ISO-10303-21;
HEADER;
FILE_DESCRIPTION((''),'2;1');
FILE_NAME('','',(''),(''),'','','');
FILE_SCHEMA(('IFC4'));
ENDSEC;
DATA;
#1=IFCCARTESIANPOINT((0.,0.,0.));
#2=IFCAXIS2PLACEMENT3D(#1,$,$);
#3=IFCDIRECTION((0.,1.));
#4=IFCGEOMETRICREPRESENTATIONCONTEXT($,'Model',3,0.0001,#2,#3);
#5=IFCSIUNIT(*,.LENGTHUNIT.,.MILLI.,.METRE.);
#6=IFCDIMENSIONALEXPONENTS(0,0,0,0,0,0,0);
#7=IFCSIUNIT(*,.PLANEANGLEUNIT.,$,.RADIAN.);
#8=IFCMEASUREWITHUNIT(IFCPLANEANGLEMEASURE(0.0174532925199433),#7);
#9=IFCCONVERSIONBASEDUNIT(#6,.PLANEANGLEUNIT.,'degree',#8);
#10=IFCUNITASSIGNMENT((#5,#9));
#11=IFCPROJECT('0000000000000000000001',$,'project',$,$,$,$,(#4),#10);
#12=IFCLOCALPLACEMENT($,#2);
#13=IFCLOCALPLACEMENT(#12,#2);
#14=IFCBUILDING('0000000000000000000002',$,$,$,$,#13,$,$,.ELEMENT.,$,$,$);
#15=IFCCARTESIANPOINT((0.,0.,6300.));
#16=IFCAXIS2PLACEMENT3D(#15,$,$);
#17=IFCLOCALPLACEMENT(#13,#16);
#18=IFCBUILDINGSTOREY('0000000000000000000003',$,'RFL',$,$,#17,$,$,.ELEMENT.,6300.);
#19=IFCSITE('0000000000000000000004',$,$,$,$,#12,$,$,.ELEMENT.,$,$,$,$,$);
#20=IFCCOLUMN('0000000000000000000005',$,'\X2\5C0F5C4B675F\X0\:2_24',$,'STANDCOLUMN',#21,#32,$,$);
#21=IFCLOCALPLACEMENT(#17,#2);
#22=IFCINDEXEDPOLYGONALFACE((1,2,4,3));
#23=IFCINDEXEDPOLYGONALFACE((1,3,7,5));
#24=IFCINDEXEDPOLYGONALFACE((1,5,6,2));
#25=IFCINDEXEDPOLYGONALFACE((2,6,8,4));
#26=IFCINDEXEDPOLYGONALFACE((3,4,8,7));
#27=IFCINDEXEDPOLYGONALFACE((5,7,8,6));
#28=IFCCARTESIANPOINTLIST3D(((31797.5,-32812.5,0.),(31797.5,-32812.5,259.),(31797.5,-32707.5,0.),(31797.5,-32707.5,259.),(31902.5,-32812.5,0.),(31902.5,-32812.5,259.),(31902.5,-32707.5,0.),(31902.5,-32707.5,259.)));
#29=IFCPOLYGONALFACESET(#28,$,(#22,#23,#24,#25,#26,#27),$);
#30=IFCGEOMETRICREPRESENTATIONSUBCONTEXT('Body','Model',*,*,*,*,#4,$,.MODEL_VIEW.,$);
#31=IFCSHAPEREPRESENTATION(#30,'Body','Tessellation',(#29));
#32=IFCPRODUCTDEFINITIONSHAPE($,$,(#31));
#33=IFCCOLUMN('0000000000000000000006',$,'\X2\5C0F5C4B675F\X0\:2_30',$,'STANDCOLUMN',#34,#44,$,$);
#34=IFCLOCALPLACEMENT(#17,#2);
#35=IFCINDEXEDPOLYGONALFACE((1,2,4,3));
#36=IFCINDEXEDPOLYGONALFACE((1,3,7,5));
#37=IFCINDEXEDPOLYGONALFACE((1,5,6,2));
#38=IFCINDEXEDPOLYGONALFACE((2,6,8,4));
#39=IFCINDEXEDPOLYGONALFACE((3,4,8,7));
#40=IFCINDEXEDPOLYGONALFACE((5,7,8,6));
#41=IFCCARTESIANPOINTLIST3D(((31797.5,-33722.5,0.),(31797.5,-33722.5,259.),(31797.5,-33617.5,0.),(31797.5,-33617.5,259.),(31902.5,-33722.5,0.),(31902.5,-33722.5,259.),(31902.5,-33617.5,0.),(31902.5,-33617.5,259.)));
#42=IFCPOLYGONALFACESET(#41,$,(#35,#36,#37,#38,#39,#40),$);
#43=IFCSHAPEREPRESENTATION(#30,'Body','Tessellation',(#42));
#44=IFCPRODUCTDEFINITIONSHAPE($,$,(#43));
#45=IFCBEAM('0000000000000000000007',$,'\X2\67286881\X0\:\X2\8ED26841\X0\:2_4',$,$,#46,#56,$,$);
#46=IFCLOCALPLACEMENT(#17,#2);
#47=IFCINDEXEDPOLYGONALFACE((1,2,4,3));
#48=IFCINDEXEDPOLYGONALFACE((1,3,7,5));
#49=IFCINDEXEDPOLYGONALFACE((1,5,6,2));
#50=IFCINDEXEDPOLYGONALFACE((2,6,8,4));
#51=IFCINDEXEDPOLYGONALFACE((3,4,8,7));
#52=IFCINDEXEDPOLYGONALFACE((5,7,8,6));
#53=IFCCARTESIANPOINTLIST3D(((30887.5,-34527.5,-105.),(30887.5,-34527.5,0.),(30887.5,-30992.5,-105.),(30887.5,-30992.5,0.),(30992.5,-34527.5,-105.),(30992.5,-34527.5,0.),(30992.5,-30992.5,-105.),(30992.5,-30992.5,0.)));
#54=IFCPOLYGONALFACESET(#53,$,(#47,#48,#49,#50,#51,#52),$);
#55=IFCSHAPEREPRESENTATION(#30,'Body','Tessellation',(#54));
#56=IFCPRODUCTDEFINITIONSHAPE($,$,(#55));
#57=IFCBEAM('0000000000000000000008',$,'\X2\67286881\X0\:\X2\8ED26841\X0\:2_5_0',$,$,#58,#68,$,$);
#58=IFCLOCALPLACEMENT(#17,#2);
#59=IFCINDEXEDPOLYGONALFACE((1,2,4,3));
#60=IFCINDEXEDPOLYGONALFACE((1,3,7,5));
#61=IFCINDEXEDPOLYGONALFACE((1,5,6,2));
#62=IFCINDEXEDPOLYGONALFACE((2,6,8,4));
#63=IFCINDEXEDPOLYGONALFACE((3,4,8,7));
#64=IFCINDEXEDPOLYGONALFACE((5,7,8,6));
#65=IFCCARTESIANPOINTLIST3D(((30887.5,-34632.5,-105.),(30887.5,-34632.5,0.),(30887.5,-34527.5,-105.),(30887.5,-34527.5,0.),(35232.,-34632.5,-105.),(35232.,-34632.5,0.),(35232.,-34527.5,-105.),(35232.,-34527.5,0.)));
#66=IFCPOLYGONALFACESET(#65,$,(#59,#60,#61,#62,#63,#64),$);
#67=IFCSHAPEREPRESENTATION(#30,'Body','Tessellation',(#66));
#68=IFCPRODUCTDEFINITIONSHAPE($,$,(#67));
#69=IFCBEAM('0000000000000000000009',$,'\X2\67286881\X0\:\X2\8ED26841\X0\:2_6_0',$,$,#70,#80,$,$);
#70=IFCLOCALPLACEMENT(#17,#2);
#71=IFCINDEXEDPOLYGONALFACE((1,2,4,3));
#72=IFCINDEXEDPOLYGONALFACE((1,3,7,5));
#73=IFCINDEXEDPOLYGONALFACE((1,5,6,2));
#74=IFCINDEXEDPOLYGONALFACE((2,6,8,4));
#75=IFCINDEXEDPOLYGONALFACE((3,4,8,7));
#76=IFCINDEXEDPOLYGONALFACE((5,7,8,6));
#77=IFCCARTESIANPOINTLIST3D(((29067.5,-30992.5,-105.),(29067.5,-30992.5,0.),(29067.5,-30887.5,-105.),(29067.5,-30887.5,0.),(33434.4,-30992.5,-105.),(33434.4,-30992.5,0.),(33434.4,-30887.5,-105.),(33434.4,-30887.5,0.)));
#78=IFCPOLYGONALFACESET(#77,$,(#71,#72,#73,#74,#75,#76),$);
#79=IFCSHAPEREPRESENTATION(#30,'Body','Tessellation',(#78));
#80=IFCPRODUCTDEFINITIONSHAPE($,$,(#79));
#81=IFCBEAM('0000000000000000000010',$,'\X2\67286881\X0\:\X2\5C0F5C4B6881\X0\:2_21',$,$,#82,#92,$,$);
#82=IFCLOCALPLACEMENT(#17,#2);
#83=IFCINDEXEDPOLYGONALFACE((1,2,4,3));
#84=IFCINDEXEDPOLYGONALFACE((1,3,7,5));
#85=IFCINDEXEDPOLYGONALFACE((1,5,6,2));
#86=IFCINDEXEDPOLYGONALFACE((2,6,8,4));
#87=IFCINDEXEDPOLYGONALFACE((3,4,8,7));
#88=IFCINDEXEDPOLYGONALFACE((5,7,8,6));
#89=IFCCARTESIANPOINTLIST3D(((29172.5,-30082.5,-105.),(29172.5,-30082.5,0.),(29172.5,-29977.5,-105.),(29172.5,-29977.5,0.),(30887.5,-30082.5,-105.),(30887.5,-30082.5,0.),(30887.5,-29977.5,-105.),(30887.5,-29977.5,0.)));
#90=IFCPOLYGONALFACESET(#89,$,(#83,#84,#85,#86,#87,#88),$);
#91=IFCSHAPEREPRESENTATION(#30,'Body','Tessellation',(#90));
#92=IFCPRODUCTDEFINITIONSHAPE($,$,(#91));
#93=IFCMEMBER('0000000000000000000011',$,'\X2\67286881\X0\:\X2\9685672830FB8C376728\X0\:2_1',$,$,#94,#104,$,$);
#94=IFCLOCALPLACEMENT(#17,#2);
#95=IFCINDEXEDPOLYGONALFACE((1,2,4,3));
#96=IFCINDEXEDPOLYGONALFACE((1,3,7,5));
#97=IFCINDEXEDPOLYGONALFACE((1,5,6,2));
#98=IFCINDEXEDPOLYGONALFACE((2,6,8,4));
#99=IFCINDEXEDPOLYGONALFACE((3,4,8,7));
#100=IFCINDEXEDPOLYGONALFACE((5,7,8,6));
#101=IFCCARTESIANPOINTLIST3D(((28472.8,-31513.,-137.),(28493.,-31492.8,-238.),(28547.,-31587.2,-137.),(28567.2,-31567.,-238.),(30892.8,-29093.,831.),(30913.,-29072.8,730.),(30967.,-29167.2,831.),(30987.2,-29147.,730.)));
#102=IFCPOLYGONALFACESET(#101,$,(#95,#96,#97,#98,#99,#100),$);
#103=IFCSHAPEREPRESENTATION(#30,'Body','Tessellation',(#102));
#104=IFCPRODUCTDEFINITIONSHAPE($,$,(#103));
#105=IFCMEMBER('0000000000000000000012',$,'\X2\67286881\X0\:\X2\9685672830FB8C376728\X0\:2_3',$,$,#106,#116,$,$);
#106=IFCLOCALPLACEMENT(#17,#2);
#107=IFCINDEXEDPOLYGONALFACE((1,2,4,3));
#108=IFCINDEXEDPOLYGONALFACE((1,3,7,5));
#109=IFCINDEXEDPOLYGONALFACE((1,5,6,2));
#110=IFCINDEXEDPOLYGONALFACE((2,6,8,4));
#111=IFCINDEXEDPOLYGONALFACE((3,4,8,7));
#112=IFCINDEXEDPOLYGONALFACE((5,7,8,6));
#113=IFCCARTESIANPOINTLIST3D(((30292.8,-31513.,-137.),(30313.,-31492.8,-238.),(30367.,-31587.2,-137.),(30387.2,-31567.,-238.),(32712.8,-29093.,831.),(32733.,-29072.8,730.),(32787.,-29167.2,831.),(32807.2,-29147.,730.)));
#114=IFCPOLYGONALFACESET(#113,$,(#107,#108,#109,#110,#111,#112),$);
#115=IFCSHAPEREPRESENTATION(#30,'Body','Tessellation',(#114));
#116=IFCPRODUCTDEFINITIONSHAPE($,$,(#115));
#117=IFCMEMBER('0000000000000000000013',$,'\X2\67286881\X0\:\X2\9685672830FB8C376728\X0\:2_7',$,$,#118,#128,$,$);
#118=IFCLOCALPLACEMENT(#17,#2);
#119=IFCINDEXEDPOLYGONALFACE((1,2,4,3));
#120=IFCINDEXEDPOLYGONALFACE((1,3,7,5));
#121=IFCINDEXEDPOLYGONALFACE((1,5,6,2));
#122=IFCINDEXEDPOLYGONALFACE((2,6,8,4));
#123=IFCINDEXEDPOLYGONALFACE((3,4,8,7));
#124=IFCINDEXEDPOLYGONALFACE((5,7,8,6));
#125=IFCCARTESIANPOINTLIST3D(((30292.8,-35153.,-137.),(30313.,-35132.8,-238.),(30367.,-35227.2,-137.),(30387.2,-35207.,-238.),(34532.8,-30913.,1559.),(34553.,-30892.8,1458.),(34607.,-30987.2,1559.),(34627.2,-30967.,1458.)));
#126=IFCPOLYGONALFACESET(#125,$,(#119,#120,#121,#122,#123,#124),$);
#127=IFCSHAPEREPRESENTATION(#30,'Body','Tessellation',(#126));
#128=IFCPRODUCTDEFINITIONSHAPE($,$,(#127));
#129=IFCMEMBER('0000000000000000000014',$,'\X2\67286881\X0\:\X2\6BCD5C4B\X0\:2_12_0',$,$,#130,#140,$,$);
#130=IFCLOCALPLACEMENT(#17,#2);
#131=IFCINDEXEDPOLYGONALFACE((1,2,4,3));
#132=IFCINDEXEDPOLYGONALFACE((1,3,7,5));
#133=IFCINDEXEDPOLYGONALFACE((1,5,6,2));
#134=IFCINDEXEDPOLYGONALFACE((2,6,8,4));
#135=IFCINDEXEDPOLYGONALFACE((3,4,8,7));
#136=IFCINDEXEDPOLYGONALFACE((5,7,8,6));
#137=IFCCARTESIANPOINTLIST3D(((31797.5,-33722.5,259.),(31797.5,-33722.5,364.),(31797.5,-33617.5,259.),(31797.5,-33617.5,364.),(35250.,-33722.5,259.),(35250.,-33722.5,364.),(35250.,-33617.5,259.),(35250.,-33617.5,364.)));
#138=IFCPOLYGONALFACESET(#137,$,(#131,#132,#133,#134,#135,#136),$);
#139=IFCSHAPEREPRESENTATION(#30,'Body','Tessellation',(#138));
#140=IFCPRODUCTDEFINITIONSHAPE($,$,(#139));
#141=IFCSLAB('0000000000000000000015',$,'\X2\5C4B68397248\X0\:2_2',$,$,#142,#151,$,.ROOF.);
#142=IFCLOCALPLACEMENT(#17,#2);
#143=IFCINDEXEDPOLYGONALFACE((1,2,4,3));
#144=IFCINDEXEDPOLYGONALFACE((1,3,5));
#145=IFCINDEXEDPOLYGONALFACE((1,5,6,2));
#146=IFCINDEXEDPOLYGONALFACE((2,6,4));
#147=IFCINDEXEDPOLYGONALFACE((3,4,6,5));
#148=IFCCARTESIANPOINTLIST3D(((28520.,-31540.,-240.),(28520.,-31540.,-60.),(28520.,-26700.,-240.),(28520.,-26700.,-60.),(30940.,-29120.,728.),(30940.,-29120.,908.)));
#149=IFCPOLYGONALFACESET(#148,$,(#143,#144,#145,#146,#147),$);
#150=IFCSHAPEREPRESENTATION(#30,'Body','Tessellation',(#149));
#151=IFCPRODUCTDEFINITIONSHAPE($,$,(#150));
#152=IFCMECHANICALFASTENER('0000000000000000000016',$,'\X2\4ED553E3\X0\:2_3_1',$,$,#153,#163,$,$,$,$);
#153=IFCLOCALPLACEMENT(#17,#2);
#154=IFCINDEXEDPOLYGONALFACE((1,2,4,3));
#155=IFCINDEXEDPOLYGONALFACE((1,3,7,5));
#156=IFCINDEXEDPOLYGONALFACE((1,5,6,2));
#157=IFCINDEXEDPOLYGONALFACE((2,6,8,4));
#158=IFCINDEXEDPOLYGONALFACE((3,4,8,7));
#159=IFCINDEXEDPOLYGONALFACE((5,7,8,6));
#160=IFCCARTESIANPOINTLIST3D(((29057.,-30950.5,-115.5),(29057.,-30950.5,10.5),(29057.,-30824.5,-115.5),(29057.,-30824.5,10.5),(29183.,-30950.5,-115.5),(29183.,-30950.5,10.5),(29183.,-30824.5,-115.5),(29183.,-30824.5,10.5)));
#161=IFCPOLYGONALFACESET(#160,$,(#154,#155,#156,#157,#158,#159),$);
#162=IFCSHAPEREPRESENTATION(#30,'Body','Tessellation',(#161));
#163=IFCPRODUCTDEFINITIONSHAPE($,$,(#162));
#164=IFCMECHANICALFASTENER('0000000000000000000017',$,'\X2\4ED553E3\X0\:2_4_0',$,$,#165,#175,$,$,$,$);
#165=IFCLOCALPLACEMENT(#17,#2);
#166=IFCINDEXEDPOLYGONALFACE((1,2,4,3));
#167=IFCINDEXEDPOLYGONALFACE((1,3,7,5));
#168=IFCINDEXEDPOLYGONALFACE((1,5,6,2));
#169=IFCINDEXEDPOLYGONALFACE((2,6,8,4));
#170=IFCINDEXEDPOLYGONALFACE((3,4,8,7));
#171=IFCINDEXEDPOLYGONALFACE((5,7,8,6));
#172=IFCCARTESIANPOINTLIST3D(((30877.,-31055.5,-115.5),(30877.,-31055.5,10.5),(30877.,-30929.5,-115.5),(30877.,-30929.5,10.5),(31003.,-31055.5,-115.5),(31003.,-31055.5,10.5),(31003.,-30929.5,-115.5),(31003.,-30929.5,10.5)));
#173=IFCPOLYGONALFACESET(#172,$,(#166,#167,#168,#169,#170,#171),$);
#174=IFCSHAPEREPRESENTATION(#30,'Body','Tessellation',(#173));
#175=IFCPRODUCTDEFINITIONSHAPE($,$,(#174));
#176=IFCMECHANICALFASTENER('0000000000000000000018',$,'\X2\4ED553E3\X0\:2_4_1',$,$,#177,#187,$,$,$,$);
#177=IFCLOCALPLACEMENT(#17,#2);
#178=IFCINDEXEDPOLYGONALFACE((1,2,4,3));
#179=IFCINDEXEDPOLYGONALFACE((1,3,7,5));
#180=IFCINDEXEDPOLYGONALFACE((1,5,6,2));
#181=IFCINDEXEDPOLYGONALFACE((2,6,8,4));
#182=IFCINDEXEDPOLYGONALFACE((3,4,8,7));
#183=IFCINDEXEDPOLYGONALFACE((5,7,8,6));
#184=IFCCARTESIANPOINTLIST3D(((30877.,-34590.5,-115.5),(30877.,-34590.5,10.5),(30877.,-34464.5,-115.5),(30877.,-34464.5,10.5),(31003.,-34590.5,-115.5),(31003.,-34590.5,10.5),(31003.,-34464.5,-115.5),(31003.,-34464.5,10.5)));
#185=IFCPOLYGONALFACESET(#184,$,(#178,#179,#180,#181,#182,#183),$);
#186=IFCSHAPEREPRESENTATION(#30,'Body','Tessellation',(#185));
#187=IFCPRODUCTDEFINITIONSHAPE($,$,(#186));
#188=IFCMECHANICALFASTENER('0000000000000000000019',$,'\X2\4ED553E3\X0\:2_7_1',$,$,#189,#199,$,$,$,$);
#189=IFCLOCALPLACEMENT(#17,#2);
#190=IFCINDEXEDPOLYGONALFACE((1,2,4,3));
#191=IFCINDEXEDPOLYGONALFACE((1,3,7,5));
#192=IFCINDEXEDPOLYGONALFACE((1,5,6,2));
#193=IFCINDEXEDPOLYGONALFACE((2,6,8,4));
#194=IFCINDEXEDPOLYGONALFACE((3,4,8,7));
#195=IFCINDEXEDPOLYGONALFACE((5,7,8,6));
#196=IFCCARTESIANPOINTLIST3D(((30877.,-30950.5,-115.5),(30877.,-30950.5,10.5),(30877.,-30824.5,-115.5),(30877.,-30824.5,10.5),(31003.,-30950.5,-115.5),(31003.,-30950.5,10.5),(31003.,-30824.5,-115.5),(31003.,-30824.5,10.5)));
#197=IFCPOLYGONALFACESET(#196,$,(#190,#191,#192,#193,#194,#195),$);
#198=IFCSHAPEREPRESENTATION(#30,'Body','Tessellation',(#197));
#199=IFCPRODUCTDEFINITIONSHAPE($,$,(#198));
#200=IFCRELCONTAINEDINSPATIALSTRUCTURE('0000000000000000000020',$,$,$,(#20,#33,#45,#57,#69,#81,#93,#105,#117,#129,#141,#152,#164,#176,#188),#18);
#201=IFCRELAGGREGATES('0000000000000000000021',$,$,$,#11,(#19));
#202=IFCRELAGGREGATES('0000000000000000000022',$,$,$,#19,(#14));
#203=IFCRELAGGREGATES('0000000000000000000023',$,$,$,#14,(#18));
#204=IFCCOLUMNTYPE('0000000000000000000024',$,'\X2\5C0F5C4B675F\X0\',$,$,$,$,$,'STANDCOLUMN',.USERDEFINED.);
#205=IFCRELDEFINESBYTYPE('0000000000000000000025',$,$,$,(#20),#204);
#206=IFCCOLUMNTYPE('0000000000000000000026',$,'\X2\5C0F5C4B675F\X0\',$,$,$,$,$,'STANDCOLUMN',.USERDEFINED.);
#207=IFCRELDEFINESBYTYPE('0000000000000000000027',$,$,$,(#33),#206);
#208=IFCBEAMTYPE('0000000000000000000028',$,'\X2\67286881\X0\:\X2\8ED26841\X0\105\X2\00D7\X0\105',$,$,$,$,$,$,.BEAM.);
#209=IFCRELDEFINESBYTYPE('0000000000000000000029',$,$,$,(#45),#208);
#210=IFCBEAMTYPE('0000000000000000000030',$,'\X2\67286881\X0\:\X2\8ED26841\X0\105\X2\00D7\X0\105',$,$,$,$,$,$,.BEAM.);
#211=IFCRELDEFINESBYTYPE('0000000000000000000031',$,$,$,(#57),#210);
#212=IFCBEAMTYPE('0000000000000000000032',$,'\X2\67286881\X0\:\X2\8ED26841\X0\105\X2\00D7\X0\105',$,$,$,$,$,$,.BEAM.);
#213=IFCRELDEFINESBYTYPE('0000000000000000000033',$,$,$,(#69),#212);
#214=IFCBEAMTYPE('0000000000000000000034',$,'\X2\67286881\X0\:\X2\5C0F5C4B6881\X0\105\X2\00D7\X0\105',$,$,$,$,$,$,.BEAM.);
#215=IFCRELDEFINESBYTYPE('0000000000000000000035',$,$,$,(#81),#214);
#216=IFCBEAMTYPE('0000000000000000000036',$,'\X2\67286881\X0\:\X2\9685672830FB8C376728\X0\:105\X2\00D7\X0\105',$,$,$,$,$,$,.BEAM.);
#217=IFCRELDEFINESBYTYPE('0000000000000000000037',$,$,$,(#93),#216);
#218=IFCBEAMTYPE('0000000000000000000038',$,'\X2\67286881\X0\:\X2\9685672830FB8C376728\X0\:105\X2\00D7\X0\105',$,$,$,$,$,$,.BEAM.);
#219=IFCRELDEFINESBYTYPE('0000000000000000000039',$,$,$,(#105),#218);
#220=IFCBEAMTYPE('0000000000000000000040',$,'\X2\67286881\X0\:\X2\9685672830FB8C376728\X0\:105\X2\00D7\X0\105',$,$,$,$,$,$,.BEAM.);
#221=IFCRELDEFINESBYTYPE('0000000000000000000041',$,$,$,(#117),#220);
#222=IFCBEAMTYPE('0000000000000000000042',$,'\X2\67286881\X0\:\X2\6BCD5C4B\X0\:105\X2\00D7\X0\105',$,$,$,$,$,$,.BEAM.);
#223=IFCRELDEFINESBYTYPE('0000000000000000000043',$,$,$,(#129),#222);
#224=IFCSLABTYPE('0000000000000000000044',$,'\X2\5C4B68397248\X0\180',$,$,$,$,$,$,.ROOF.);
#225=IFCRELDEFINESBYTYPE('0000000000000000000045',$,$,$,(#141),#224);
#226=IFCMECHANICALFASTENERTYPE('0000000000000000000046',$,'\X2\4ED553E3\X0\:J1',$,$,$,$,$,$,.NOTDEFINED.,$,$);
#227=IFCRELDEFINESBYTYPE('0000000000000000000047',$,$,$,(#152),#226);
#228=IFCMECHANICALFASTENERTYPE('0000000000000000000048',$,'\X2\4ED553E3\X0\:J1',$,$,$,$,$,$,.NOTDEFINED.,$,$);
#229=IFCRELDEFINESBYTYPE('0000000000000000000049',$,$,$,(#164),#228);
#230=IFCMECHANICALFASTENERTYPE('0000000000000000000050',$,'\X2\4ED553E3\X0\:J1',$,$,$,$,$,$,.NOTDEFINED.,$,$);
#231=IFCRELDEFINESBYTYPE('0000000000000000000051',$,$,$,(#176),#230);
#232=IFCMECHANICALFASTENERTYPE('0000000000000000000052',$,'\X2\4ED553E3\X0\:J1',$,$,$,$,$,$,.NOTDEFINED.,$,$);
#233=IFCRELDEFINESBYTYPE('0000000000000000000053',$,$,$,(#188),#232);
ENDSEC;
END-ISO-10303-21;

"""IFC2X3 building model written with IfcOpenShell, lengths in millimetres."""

from ifc_helpers import new_model, entity, si_unit, converted_unit, direction, frame, origin, origin_with_axes, origin_2d, place, context, subcontext, project, spatial, polyline, rectangle, outline, extrude, type_object, element, save


model = new_model("IFC2X3")

# Units and contexts
model_context = context("Model", 3, precision=0.0001, world=origin(), true_north=direction((0.0, 1.0)))
body_context = subcontext(model_context, "Body", "Model", "MODEL_VIEW")
ifc_project = project(units=[si_unit("LENGTHUNIT", "METRE", prefix="MILLI"), converted_unit("PLANEANGLEUNIT", "degree", entity("IfcPlaneAngleMeasure", 0.0174532925199433), si_unit("PLANEANGLEUNIT", "RADIAN"), dimensions=[0, 0, 0, 0, 0, 0, 0])], contexts=[model_context])

# Site, building, storey
site_placement = place(None, origin())
site = spatial("IfcSite", under=ifc_project, at=site_placement, CompositionType="ELEMENT")
building_placement = place(site_placement, origin())
building = spatial("IfcBuilding", under=site, at=building_placement, CompositionType="ELEMENT")
storey_placement = place(building_placement, frame((0.0, 0.0, 6300.0)))
storey = spatial("IfcBuildingStorey", under=building, at=storey_placement, Name="RFL", CompositionType="ELEMENT", Elevation=6300.0)

# Columns
column_type_1 = type_object("IfcColumnType", Name="小屋束", ElementType="STANDCOLUMN", PredefinedType="USERDEFINED")
column_1_placement = place(storey_placement, frame((31850.0, -32760.0, 0.0)))
element("IfcColumn", 1, at=column_1_placement, inside=storey, type_object=column_type_1, Name="小屋束:2_24", ObjectType="STANDCOLUMN", context=body_context, shape_type="SweptSolid", body=[
    extrude(rectangle(XDim=105.0, YDim=105.0, at=origin_2d()), origin_with_axes(), (0.0, 0.0, 1.0), 259.0),
])
column_type_2 = type_object("IfcColumnType", Name="小屋束", ElementType="STANDCOLUMN", PredefinedType="USERDEFINED")
column_2_placement = place(storey_placement, frame((31850.0, -33670.0, 0.0)))
element("IfcColumn", 2, at=column_2_placement, inside=storey, type_object=column_type_2, Name="小屋束:2_30", ObjectType="STANDCOLUMN", context=body_context, shape_type="SweptSolid", body=[
    extrude(rectangle(XDim=105.0, YDim=105.0, at=origin_2d()), origin_with_axes(), (0.0, 0.0, 1.0), 259.0),
])

# Beams
beam_type_1 = type_object("IfcBeamType", Name="木梁:軒桁105×105", PredefinedType="BEAM")
beam_1_placement = place(storey_placement, frame((30940.0, -30992.5, -52.5), z_axis=(0.0, -1.0, 0.0), x_axis=(1.0, 0.0, 0.0)))
element("IfcBeam", 3, at=beam_1_placement, inside=storey, type_object=beam_type_1, Name="木梁:軒桁:2_4", context=body_context, shape_type="SweptSolid", body=[
    extrude(rectangle(XDim=105.0, YDim=105.0, at=origin_2d()), origin_with_axes(), (0.0, 0.0, 1.0), 3535.0),
])
beam_type_2 = type_object("IfcBeamType", Name="木梁:軒桁105×105", PredefinedType="BEAM")
beam_2_placement = place(storey_placement, frame((30887.5, -34580.0, -52.5), z_axis=(1.0, 0.0, 0.0), x_axis=(0.0, 1.0, 0.0)))
element("IfcBeam", 4, at=beam_2_placement, inside=storey, type_object=beam_type_2, Name="木梁:軒桁:2_5_0", context=body_context, shape_type="SweptSolid", body=[
    extrude(rectangle(XDim=105.0, YDim=105.0, at=origin_2d()), origin_with_axes(), (0.0, 0.0, 1.0), 4344.5),
])
beam_type_3 = type_object("IfcBeamType", Name="木梁:軒桁105×105", PredefinedType="BEAM")
beam_3_placement = place(storey_placement, frame((29067.5, -30940.0, -52.5), z_axis=(1.0, 0.0, 0.0), x_axis=(0.0, 1.0, 0.0)))
element("IfcBeam", 5, at=beam_3_placement, inside=storey, type_object=beam_type_3, Name="木梁:軒桁:2_6_0", context=body_context, shape_type="SweptSolid", body=[
    extrude(rectangle(XDim=105.0, YDim=105.0, at=origin_2d()), origin_with_axes(), (0.0, 0.0, 1.0), 4366.9),
])
beam_type_4 = type_object("IfcBeamType", Name="木梁:小屋梁105×105", PredefinedType="BEAM")
beam_4_placement = place(storey_placement, frame((29172.5, -30030.0, -52.5), z_axis=(1.0, 0.0, 0.0), x_axis=(0.0, 1.0, 0.0)))
element("IfcBeam", 6, at=beam_4_placement, inside=storey, type_object=beam_type_4, Name="木梁:小屋梁:2_21", context=body_context, shape_type="SweptSolid", body=[
    extrude(rectangle(XDim=105.0, YDim=105.0, at=origin_2d()), origin_with_axes(), (0.0, 0.0, 1.0), 1715.0),
])

# Members
beam_type_5 = type_object("IfcBeamType", Name="木梁:隅木・谷木:105×105", PredefinedType="BEAM")
member_1_placement = place(storey_placement, frame((28520.0, -31540.0, -187.5), z_axis=(0.680414, 0.680414, 0.272166), x_axis=(0.707107, -0.707107, 0.0)))
element("IfcMember", 7, at=member_1_placement, inside=storey, type_object=beam_type_5, Name="木梁:隅木・谷木:2_1", context=body_context, shape_type="SweptSolid", body=[
    extrude(rectangle(XDim=105.0, YDim=105.0, at=origin_2d()), origin_with_axes(), (0.0, 0.0, 1.0), 3556.7),
])
beam_type_6 = type_object("IfcBeamType", Name="木梁:隅木・谷木:105×105", PredefinedType="BEAM")
member_2_placement = place(storey_placement, frame((30340.0, -31540.0, -187.5), z_axis=(0.680414, 0.680414, 0.272166), x_axis=(0.707107, -0.707107, 0.0)))
element("IfcMember", 8, at=member_2_placement, inside=storey, type_object=beam_type_6, Name="木梁:隅木・谷木:2_3", context=body_context, shape_type="SweptSolid", body=[
    extrude(rectangle(XDim=105.0, YDim=105.0, at=origin_2d()), origin_with_axes(), (0.0, 0.0, 1.0), 3556.7),
])
beam_type_7 = type_object("IfcBeamType", Name="木梁:隅木・谷木:105×105", PredefinedType="BEAM")
member_3_placement = place(storey_placement, frame((30340.0, -35180.0, -187.5), z_axis=(0.680414, 0.680414, 0.272166), x_axis=(0.707107, -0.707107, 0.0)))
element("IfcMember", 9, at=member_3_placement, inside=storey, type_object=beam_type_7, Name="木梁:隅木・谷木:2_7", context=body_context, shape_type="SweptSolid", body=[
    extrude(rectangle(XDim=105.0, YDim=105.0, at=origin_2d()), origin_with_axes(), (0.0, 0.0, 1.0), 6231.5),
])
beam_type_8 = type_object("IfcBeamType", Name="木梁:母屋:105×105", PredefinedType="BEAM")
member_4_placement = place(storey_placement, frame((31797.5, -33670.0, 311.5), z_axis=(1.0, 0.0, 0.0), x_axis=(0.0, -1.0, 0.0)))
element("IfcMember", 10, at=member_4_placement, inside=storey, type_object=beam_type_8, Name="木梁:母屋:2_12_0", context=body_context, shape_type="SweptSolid", body=[
    extrude(rectangle(XDim=105.0, YDim=105.0, at=origin_2d()), origin_with_axes(), (0.0, 0.0, 1.0), 3452.5),
])

# Slab
slab_type = type_object("IfcSlabType", Name="屋根版180", PredefinedType="ROOF")
slab_placement = place(storey_placement, frame((28520.0, -31540.0, -240.0), z_axis=(0.371391, 0.0, -0.928477), x_axis=(0.0, 1.0, 0.0)))
element("IfcSlab", 11, at=slab_placement, inside=storey, type_object=slab_type, Name="屋根版:2_2", PredefinedType="ROOF", context=body_context, shape_type="SweptSolid", body=[
    extrude(outline(polyline([(0.0, 0.0, 0.0), (4840.0, 0.0, 0.0), (2420.0, 2606.4, 0.0), (0.0, 0.0, 0.0)])), origin_with_axes(), (0.0, 0.371391, -0.928477), 180.0),
])

# Mechanical fasteners
mechanical_fastener_type_1 = type_object("IfcMechanicalFastenerType", Name="仕口:J1")
mechanical_fastener_1_placement = place(storey_placement, frame((29120.0, -30887.5, -115.5)))
element("IfcMechanicalFastener", 12, at=mechanical_fastener_1_placement, inside=storey, type_object=mechanical_fastener_type_1, Name="仕口:2_3_1", context=body_context, shape_type="SweptSolid", body=[
    extrude(rectangle(XDim=126.0, YDim=126.0, at=origin_2d()), origin_with_axes(), (0.0, 0.0, 1.0), 126.0),
])
mechanical_fastener_type_2 = type_object("IfcMechanicalFastenerType", Name="仕口:J1")
mechanical_fastener_2_placement = place(storey_placement, frame((30940.0, -30992.5, -115.5)))
element("IfcMechanicalFastener", 13, at=mechanical_fastener_2_placement, inside=storey, type_object=mechanical_fastener_type_2, Name="仕口:2_4_0", context=body_context, shape_type="SweptSolid", body=[
    extrude(rectangle(XDim=126.0, YDim=126.0, at=origin_2d()), origin_with_axes(), (0.0, 0.0, 1.0), 126.0),
])
mechanical_fastener_type_3 = type_object("IfcMechanicalFastenerType", Name="仕口:J1")
mechanical_fastener_3_placement = place(storey_placement, frame((30940.0, -34527.5, -115.5)))
element("IfcMechanicalFastener", 14, at=mechanical_fastener_3_placement, inside=storey, type_object=mechanical_fastener_type_3, Name="仕口:2_4_1", context=body_context, shape_type="SweptSolid", body=[
    extrude(rectangle(XDim=126.0, YDim=126.0, at=origin_2d()), origin_with_axes(), (0.0, 0.0, 1.0), 126.0),
])
mechanical_fastener_type_4 = type_object("IfcMechanicalFastenerType", Name="仕口:J1")
mechanical_fastener_4_placement = place(storey_placement, frame((30940.0, -30887.5, -115.5)))
element("IfcMechanicalFastener", 15, at=mechanical_fastener_4_placement, inside=storey, type_object=mechanical_fastener_type_4, Name="仕口:2_7_1", context=body_context, shape_type="SweptSolid", body=[
    extrude(rectangle(XDim=126.0, YDim=126.0, at=origin_2d()), origin_with_axes(), (0.0, 0.0, 1.0), 126.0),
])

save(model, "model.ifc")
